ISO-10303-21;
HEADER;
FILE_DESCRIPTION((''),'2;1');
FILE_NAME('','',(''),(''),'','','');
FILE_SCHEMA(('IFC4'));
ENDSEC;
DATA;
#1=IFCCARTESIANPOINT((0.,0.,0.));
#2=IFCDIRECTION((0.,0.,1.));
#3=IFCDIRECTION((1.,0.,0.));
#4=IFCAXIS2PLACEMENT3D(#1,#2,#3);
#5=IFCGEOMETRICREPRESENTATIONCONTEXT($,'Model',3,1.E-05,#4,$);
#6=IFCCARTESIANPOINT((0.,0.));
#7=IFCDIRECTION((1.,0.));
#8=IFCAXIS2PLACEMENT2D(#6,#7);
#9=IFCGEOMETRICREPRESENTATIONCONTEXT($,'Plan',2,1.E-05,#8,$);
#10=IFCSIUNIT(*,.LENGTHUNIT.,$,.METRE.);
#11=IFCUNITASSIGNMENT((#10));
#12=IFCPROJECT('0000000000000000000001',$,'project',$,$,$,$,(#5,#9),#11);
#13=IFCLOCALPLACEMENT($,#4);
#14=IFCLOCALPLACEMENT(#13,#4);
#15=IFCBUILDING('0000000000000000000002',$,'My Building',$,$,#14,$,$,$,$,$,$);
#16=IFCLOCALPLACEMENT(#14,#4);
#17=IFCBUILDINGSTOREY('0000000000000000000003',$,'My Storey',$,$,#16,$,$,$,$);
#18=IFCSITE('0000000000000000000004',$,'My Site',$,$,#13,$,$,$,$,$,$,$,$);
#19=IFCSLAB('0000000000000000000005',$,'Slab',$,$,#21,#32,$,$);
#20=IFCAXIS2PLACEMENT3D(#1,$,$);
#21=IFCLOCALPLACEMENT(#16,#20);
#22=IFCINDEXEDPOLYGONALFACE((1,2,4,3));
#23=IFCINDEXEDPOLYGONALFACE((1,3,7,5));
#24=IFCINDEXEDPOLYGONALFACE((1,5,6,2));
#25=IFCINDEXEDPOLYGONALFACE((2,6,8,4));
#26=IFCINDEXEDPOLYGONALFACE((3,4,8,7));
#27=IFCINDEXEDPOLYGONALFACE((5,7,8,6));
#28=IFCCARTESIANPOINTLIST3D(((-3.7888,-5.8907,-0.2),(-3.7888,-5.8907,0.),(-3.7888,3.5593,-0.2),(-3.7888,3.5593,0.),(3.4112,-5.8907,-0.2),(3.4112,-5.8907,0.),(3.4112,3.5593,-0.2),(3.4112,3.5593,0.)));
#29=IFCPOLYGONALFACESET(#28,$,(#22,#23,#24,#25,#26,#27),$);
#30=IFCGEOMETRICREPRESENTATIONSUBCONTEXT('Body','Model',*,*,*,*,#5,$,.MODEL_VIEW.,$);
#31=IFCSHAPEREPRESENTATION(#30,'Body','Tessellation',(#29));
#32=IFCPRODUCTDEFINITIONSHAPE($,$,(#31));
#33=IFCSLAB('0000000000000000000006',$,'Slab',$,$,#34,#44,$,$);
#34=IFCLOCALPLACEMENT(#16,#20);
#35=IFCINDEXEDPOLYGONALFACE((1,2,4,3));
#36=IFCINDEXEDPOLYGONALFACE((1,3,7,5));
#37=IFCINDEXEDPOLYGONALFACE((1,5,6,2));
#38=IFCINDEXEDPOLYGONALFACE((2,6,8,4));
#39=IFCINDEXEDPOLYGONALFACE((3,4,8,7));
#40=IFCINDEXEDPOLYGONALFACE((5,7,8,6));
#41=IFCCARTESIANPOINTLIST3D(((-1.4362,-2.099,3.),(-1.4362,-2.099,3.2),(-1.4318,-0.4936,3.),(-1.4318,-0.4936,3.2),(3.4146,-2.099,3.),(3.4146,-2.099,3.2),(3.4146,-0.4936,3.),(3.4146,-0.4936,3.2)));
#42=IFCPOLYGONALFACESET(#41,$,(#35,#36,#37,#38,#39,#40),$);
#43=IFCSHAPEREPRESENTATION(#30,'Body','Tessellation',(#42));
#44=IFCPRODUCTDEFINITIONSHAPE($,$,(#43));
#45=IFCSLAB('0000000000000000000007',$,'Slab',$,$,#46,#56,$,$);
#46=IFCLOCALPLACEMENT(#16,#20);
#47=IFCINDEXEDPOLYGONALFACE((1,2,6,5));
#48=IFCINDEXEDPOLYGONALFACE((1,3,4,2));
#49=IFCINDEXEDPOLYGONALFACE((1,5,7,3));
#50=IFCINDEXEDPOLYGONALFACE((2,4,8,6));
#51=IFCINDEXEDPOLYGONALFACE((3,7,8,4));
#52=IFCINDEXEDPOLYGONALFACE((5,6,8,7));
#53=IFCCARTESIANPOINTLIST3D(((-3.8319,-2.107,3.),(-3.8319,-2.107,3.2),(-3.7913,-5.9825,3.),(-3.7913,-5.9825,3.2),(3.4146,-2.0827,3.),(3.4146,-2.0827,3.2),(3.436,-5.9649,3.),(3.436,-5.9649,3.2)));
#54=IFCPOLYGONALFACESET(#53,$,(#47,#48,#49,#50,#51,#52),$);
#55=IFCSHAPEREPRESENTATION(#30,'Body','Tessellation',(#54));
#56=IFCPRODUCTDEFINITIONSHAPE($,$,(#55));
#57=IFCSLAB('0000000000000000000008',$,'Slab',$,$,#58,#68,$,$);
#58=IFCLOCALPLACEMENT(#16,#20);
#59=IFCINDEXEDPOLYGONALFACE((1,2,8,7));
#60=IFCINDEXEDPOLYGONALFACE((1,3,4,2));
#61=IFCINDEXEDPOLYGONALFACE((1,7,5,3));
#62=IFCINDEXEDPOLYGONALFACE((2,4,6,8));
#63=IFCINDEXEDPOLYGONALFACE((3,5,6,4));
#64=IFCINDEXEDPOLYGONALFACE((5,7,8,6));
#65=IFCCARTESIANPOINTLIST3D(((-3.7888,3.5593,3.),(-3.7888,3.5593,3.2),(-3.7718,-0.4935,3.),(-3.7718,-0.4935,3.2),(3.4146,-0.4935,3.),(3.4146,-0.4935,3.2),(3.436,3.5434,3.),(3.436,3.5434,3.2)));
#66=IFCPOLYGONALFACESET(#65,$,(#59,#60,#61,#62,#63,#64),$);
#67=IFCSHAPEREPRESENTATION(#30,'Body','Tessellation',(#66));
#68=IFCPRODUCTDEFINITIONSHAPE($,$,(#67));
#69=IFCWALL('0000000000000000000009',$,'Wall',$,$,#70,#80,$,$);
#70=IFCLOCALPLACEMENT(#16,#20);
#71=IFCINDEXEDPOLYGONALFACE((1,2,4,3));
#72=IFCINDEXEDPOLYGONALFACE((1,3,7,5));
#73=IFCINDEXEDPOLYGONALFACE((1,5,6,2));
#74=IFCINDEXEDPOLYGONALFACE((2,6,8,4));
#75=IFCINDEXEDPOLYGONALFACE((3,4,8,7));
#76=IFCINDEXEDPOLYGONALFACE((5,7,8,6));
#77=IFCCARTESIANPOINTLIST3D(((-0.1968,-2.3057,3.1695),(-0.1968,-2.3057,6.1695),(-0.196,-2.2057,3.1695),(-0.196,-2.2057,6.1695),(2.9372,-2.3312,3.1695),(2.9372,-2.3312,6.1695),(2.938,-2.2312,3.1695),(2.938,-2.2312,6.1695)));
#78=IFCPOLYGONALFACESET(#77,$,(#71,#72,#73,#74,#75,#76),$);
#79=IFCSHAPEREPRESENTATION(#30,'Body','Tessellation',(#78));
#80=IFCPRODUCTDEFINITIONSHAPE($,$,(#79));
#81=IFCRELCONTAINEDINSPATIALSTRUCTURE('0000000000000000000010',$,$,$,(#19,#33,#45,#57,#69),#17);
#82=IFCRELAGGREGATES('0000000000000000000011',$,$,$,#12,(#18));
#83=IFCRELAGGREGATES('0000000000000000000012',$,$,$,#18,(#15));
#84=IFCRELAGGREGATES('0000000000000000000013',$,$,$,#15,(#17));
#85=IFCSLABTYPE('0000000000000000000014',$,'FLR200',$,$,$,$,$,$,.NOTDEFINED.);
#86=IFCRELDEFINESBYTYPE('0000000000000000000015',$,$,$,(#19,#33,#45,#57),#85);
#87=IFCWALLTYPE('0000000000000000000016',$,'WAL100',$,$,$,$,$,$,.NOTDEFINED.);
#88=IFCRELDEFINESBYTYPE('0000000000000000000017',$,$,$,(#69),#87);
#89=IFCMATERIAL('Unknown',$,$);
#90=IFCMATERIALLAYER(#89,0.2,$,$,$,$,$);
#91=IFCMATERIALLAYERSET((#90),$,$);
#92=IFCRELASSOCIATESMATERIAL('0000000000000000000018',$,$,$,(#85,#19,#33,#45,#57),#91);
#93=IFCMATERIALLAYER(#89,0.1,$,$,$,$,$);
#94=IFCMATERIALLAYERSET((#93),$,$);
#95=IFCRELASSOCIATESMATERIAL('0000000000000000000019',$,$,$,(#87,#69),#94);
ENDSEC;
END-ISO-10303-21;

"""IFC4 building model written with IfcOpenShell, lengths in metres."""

from ifc_helpers import new_model, si_unit, frame, origin_with_axes, origin_2d_with_axis, place, context, subcontext, project, spatial, line, indexed_curve, outline, extrude, material, layer, layer_set, layer_usage, type_object, element, save


model = new_model("IFC4")

# Units and contexts
model_context = context("Model", 3, precision=1e-05, world=origin_with_axes())
plan_context = context("Plan", 2, precision=1e-05, world=origin_2d_with_axis())
body_context_1 = subcontext(model_context, "Body", "Model", "MODEL_VIEW")
ifc_project = project(units=[si_unit("LENGTHUNIT", "METRE")], contexts=[model_context, plan_context])

# Site, building, storey
site_placement = place(None, origin_with_axes())
site = spatial("IfcSite", under=ifc_project, at=site_placement, Name="My Site")
building_placement = place(site_placement, origin_with_axes())
building = spatial("IfcBuilding", under=site, at=building_placement, Name="My Building")
storey_placement = place(building_placement, origin_with_axes())
storey = spatial("IfcBuildingStorey", under=building, at=storey_placement, Name="My Storey")

# Slabs
ifc_material = material(Name="Unknown")
ifc_layer_1 = layer(ifc_material, 0.2)
ifc_layer_set_1 = layer_set([ifc_layer_1])
ifc_layer_usage_1 = layer_usage(ifc_layer_set_1, "AXIS3", "POSITIVE", -0.2)
slab_type = type_object("IfcSlabType", Name="FLR200", PredefinedType="NOTDEFINED", material=ifc_layer_set_1)
slab_1_placement = place(storey_placement, frame((-3.7888, 3.5593, 0.0), z_axis=(0.0, 0.0, 1.0), x_axis=(1.0, 0.0, 0.0)))
element("IfcSlab", 1, at=slab_1_placement, inside=storey, type_object=slab_type, material=ifc_layer_usage_1, Name="Slab", context=body_context_1, shape_type="SweptSolid", body=[
    extrude(outline(indexed_curve([(0.0, 0.0), (7.2, 0.0), (7.2, -9.45), (0.0, -9.45), (0.0, 0.0)])), frame((0.0, 0.0, -0.2), z_axis=(0.0, 0.0, 1.0), x_axis=(1.0, 0.0, 0.0)), (0.0, 0.0, 1.0), 0.2),
])
ifc_layer_usage_2 = layer_usage(ifc_layer_set_1, "AXIS3", "POSITIVE", -0.2)
slab_2_placement = place(storey_placement, frame((-1.4318, -0.4436, 3.2), z_axis=(0.0, 0.0, 1.0), x_axis=(1.0, 0.0, 0.0)))
element("IfcSlab", 2, at=slab_2_placement, inside=storey, type_object=slab_type, material=ifc_layer_usage_2, Name="Slab", context=body_context_1, shape_type="SweptSolid", body=[
    extrude(outline(indexed_curve([(4.8464, 0.0), (4.8464, -1.6054), (-0.0044, -1.6054), (0.0, 0.0), (4.8464, 0.0)])), frame((0.0, -0.05, -0.2), z_axis=(0.0, 0.0, 1.0), x_axis=(1.0, 0.0, 0.0)), (0.0, 0.0, 1.0), 0.2),
])
ifc_layer_usage_3 = layer_usage(ifc_layer_set_1, "AXIS3", "POSITIVE", -0.2)
slab_3_placement = place(storey_placement, frame((-3.8319, -2.107, 3.2), z_axis=(0.0, 0.0, 1.0), x_axis=(1.0, 0.0, 0.0)))
element("IfcSlab", 3, at=slab_3_placement, inside=storey, type_object=slab_type, material=ifc_layer_usage_3, Name="Slab", context=body_context_1, shape_type="SweptSolid", body=[
    extrude(outline(indexed_curve([(0.0, 0.0), (7.2465, 0.0242), (7.2679, -3.8579), (0.0406, -3.8755), (0.0, 0.0)])), frame((0.0, 0.0, -0.2), z_axis=(0.0, 0.0, 1.0), x_axis=(1.0, 0.0, 0.0)), (0.0, 0.0, 1.0), 0.2),
])
ifc_layer_usage_4 = layer_usage(ifc_layer_set_1, "AXIS3", "POSITIVE", -0.2)
slab_4_placement = place(storey_placement, frame((-3.7888, 3.5593, 3.2), z_axis=(0.0, 0.0, 1.0), x_axis=(1.0, 0.0, 0.0)))
element("IfcSlab", 4, at=slab_4_placement, inside=storey, type_object=slab_type, material=ifc_layer_usage_4, Name="Slab", context=body_context_1, shape_type="SweptSolid", body=[
    extrude(outline(indexed_curve([(0.0, 0.0), (7.2248, -0.0159), (7.2035, -4.0528), (0.0171, -4.0528), (0.0, 0.0)])), frame((0.0, 0.0, -0.2), z_axis=(0.0, 0.0, 1.0), x_axis=(1.0, 0.0, 0.0)), (0.0, 0.0, 1.0), 0.2),
])

# Wall
ifc_layer_2 = layer(ifc_material, 0.1)
ifc_layer_set_2 = layer_set([ifc_layer_2])
ifc_layer_usage_5 = layer_usage(ifc_layer_set_2, "AXIS2", "POSITIVE", 0.0)
wall_type_1 = type_object("IfcWallType", Name="WAL100", PredefinedType="NOTDEFINED", material=ifc_layer_set_2)
wall_1_placement = place(storey_placement, frame((-0.1968, -2.3057, 3.1695), z_axis=(0.0, 0.0, 1.0), x_axis=(0.999967, -0.008116, 0.0)))
element("IfcWall", 5, at=wall_1_placement, inside=storey, type_object=wall_type_1, material=ifc_layer_usage_5, Name="Wall", context=body_context_1, shape_type="SweptSolid", body=[
    extrude(outline(indexed_curve([(0.0, 0.0), (0.0, 0.1), (3.1341, 0.1), (3.1341, 0.0)], segments=[line(1, 2, 3, 4, 1)])), origin_with_axes(), (0.0, 0.0, 1.0), 3.0),
])

save(model, "model.ifc")
